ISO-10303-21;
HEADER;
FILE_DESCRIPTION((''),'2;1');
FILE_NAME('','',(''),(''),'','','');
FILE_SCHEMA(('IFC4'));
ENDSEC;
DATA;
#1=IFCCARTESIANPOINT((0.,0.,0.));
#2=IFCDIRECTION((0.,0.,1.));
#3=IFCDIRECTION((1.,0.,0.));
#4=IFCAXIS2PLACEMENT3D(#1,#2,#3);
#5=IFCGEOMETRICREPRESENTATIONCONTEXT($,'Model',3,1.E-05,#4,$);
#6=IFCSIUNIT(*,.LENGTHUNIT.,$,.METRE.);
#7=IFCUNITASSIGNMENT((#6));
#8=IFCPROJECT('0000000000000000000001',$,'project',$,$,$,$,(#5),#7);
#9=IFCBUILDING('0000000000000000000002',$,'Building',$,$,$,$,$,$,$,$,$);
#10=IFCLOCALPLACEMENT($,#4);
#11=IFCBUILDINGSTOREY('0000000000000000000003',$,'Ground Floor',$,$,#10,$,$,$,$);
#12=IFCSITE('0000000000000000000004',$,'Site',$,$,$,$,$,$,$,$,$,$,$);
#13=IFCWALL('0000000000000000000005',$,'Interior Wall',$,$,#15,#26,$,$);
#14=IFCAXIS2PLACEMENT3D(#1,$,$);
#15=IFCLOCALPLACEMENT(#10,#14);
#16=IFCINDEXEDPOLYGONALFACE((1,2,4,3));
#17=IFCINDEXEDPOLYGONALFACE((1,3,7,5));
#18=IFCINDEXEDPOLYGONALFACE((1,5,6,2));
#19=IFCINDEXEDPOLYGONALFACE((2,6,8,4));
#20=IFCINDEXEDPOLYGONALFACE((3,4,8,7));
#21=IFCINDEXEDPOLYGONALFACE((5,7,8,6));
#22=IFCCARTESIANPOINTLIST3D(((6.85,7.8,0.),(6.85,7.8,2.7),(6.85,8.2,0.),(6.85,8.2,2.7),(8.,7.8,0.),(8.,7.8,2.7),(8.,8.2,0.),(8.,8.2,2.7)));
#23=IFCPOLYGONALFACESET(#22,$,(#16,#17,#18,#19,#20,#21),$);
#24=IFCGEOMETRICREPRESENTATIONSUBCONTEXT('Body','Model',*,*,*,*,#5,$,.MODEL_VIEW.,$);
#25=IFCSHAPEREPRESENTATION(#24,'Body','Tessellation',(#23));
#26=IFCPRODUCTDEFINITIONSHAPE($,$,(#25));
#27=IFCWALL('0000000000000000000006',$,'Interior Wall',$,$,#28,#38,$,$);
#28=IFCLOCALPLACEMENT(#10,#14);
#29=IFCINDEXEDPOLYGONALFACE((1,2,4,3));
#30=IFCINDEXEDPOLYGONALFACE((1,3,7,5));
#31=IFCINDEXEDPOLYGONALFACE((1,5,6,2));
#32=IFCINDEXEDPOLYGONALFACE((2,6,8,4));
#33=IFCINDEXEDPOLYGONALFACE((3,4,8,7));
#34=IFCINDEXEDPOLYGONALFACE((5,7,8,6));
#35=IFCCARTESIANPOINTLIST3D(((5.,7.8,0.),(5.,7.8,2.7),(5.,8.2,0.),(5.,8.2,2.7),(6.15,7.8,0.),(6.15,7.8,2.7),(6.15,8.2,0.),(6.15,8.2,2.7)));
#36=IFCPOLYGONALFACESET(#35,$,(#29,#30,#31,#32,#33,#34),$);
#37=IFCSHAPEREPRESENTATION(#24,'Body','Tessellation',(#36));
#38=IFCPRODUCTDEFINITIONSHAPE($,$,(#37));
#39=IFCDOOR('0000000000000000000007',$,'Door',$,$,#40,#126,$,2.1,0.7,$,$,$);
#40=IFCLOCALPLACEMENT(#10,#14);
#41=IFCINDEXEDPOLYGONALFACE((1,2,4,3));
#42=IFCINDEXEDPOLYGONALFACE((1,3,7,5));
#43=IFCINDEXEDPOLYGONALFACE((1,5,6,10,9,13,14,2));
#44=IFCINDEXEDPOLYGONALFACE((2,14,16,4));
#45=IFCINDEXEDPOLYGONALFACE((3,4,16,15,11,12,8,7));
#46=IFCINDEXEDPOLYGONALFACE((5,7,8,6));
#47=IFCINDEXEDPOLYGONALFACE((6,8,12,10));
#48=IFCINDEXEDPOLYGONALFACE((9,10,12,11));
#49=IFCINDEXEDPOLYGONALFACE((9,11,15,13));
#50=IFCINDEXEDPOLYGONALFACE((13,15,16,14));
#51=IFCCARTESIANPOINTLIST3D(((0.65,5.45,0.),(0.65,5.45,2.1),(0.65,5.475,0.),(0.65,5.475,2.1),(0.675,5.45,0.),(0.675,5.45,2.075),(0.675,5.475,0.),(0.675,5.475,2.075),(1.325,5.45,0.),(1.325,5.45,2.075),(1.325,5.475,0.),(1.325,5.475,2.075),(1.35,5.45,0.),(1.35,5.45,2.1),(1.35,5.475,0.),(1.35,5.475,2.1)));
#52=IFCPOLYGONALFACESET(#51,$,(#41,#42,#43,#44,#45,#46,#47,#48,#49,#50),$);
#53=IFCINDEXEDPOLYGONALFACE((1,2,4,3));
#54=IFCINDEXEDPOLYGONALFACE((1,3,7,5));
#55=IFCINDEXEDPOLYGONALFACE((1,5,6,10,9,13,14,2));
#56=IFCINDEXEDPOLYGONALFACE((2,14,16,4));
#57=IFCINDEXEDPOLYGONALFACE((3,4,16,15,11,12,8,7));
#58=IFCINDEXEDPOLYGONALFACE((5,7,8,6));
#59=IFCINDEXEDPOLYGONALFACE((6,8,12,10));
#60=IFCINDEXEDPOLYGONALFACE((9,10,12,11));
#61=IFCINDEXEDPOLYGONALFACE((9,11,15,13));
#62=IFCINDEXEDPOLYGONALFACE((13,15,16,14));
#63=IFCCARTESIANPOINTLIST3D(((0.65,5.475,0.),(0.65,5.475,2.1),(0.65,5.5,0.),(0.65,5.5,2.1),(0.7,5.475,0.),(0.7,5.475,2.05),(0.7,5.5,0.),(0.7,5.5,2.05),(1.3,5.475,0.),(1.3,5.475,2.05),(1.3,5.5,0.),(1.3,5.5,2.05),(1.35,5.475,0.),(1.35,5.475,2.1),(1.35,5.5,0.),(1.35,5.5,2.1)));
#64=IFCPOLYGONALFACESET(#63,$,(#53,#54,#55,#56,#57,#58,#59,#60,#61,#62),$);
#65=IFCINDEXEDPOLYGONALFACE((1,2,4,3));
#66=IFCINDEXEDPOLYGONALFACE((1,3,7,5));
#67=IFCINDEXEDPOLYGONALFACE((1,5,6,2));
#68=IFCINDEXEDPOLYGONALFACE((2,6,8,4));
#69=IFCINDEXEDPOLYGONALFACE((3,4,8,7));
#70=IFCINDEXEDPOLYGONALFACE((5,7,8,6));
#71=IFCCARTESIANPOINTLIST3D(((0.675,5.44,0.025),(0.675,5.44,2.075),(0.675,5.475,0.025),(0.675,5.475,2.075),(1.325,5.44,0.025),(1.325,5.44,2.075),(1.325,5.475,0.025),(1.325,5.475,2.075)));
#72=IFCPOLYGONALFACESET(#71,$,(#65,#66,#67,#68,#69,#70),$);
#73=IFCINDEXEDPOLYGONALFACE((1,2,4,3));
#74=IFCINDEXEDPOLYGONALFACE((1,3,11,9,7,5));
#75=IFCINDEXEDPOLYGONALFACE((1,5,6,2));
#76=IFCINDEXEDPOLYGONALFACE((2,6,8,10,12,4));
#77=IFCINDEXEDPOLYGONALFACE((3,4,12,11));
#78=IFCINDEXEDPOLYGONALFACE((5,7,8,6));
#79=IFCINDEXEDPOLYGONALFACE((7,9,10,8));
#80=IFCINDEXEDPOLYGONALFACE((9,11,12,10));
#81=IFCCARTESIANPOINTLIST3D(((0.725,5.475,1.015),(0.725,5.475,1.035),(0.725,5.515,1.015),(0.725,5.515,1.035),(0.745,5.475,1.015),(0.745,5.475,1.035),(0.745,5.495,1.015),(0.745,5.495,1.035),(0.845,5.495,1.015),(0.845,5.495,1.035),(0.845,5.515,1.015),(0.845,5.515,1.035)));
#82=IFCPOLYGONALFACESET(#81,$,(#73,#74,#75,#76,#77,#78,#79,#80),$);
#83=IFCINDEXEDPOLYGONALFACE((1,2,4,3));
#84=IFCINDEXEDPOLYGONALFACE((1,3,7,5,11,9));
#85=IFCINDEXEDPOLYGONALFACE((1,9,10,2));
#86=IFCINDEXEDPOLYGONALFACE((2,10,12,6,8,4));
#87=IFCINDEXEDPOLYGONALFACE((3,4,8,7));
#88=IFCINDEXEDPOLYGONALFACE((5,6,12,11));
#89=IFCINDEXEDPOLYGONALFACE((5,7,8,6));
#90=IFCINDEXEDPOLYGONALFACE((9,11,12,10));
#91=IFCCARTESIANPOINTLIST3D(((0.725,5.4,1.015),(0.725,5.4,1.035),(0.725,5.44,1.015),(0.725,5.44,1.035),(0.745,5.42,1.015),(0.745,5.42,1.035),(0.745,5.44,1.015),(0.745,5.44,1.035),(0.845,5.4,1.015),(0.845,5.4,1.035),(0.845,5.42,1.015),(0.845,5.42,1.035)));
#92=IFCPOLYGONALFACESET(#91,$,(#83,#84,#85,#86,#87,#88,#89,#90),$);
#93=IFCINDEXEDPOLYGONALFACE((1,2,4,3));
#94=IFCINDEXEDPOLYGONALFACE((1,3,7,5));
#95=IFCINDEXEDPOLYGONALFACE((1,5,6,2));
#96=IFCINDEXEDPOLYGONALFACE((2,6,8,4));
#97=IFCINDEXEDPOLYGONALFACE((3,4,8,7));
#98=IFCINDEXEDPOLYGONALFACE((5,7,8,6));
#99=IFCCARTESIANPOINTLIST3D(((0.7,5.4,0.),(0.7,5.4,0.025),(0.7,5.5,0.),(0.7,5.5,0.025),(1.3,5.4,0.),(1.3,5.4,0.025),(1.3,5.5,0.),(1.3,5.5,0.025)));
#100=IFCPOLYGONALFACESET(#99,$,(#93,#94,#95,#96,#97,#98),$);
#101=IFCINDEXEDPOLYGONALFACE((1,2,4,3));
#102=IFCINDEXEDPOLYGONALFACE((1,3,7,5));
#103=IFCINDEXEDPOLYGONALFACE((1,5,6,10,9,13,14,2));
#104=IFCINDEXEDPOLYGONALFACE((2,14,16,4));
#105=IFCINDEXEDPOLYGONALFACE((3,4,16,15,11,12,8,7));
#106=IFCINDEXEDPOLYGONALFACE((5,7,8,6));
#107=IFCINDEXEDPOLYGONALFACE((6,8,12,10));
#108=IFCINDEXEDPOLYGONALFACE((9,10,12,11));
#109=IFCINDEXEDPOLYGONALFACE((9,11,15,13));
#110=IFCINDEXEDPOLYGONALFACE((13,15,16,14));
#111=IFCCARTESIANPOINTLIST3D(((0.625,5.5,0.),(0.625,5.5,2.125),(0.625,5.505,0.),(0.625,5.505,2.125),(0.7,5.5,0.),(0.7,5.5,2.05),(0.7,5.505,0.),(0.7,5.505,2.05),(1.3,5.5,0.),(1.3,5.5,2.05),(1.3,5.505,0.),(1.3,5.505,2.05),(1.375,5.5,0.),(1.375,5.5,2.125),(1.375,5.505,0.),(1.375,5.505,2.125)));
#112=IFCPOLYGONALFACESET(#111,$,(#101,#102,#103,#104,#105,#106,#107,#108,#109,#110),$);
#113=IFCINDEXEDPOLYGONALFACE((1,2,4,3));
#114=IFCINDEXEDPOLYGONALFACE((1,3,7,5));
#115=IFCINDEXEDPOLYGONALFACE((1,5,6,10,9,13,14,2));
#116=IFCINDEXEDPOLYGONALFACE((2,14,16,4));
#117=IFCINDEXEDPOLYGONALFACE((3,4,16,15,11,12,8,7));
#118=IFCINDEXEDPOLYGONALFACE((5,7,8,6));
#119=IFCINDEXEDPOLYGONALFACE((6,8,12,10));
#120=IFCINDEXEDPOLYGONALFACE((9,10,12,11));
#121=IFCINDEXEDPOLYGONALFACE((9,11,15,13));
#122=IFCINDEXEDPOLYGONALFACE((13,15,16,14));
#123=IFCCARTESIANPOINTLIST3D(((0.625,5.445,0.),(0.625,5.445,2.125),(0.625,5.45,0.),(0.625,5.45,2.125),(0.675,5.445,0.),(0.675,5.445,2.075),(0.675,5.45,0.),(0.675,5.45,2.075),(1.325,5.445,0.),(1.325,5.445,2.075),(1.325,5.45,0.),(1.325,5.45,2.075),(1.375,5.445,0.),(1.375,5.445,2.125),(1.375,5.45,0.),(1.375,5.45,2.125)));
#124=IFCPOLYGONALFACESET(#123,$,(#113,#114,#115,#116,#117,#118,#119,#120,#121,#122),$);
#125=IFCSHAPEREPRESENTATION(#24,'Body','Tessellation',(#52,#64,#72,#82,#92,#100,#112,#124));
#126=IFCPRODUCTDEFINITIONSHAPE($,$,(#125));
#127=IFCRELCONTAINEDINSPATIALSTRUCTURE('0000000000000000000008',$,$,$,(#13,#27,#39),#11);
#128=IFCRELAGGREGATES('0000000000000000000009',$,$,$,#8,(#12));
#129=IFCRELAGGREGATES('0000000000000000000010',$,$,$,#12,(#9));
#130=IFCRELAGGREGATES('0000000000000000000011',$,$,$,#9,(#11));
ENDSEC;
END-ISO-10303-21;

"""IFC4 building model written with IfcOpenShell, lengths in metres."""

from ifc_helpers import new_model, si_unit, frame, origin_with_axes, place, context, subcontext, project, spatial, line, indexed_curve, outline, extrude, element, save


model = new_model("IFC4")

# Units and contexts
model_context = context("Model", 3, precision=1e-05, world=origin_with_axes())
body_context = subcontext(model_context, "Body", "Model", "MODEL_VIEW")
ifc_project = project(units=[si_unit("LENGTHUNIT", "METRE")], contexts=[model_context])

# Site, building, storey
site = spatial("IfcSite", under=ifc_project, Name="Site")
building = spatial("IfcBuilding", under=site, Name="Building")
storey_placement = place(None, origin_with_axes())
storey = spatial("IfcBuildingStorey", under=building, at=storey_placement, Name="Ground Floor")

# Walls
for number, where, z_axis, x_axis, name in (
    (1, (8.0, 8.0, 0.0), (0.0, 0.0, 1.0), (-1.0, 0.0, 0.0), "Interior Wall"),
    (2, (6.15, 8.0, 0.0), (0.0, 0.0, 1.0), (-1.0, 0.0, 0.0), "Interior Wall"),
):
    element("IfcWall", number, at=place(storey_placement, frame(where, z_axis=z_axis, x_axis=x_axis)), inside=storey, Name=name, context=body_context, shape_type="SweptSolid", body=[
        extrude(outline(indexed_curve([(0.0, 0.0), (0.0, 0.4), (1.15, 0.4), (1.15, 0.0), (0.0, 0.0)], self_intersect=False)), frame((0.0, -0.2, 0.0), z_axis=(0.0, 0.0, 1.0), x_axis=(1.0, 0.0, 0.0)), (0.0, 0.0, 1.0), 2.7),
    ])

# Door
door_1_placement = place(storey_placement, frame((1.35, 5.5, 0.0), z_axis=(0.0, 0.0, 1.0), x_axis=(-1.0, 0.0, 0.0)))
element("IfcDoor", 3, at=door_1_placement, inside=storey, Name="Door", OverallHeight=2.1, OverallWidth=0.7, context=body_context, shape_type="SweptSolid", body=[
    extrude(outline(indexed_curve([(0.0, 0.0), (0.0, 2.1), (0.7, 2.1), (0.7, 0.0), (0.675, 0.0), (0.675, 2.075), (0.025, 2.075), (0.025, 0.0)], segments=[line(1, 2, 3, 4, 5, 6, 7, 8, 1)])), frame((0.0, 0.025, 0.0), z_axis=(0.0, -1.0, 0.0), x_axis=(1.0, 0.0, 0.0)), (0.0, 0.0, -1.0), 0.025),
    extrude(outline(indexed_curve([(0.0, 0.0), (0.0, 2.1), (0.7, 2.1), (0.7, 0.0), (0.65, 0.0), (0.65, 2.05), (0.05, 2.05), (0.05, 0.0)], segments=[line(1, 2, 3, 4, 5, 6, 7, 8, 1)])), frame((0.0, 0.0, 0.0), z_axis=(0.0, -1.0, 0.0), x_axis=(1.0, 0.0, 0.0)), (0.0, 0.0, -1.0), 0.025),
    extrude(outline(indexed_curve([(0.0, 0.0), (0.65, 0.0), (0.65, 0.035), (0.0, 0.035)], segments=[line(1, 2, 3, 4, 1)])), frame((0.025, 0.025, 0.025), z_axis=(0.0, 0.0, 1.0), x_axis=(1.0, 0.0, 0.0)), (0.0, 0.0, 1.0), 2.05),
    extrude(outline(indexed_curve([(0.0, 0.0), (0.0, -0.04), (-0.12, -0.04), (-0.12, -0.02), (-0.02, -0.02), (-0.02, 0.0)], segments=[line(1, 2, 3, 4, 5, 6, 1)])), frame((0.625, 0.025, 1.015), z_axis=(0.0, 0.0, 1.0), x_axis=(1.0, 0.0, 0.0)), (0.0, 0.0, 1.0), 0.02),
    extrude(outline(indexed_curve([(0.0, 0.0), (0.0, 0.04), (-0.12, 0.04), (-0.12, 0.02), (-0.02, 0.02), (-0.02, 0.0)], segments=[line(1, 2, 3, 4, 5, 6, 1)])), frame((0.625, 0.06, 1.015), z_axis=(0.0, 0.0, 1.0), x_axis=(1.0, 0.0, 0.0)), (0.0, 0.0, 1.0), 0.02),
    extrude(outline(indexed_curve([(0.0, 0.0), (0.6, 0.0), (0.6, 0.1), (0.0, 0.1)], segments=[line(1, 2, 3, 4, 1)])), frame((0.05, 0.0, 0.0), z_axis=(0.0, 0.0, 1.0), x_axis=(1.0, 0.0, 0.0)), (0.0, 0.0, 1.0), 0.025),
    extrude(outline(indexed_curve([(0.0, 0.0), (0.0, 2.125), (0.75, 2.125), (0.75, 0.0), (0.675, 0.0), (0.675, 2.05), (0.075, 2.05), (0.075, 0.0)], segments=[line(1, 2, 3, 4, 5, 6, 7, 8, 1)])), frame((-0.025, -0.005, 0.0), z_axis=(0.0, -1.0, 0.0), x_axis=(1.0, 0.0, 0.0)), (0.0, 0.0, -1.0), 0.005),
    extrude(outline(indexed_curve([(0.0, 0.0), (0.0, 2.125), (0.75, 2.125), (0.75, 0.0), (0.7, 0.0), (0.7, 2.075), (0.05, 2.075), (0.05, 0.0)], segments=[line(1, 2, 3, 4, 5, 6, 7, 8, 1)])), frame((-0.025, 0.05, 0.0), z_axis=(0.0, -1.0, 0.0), x_axis=(1.0, 0.0, 0.0)), (0.0, 0.0, -1.0), 0.005),
])

save(model, "model.ifc")
